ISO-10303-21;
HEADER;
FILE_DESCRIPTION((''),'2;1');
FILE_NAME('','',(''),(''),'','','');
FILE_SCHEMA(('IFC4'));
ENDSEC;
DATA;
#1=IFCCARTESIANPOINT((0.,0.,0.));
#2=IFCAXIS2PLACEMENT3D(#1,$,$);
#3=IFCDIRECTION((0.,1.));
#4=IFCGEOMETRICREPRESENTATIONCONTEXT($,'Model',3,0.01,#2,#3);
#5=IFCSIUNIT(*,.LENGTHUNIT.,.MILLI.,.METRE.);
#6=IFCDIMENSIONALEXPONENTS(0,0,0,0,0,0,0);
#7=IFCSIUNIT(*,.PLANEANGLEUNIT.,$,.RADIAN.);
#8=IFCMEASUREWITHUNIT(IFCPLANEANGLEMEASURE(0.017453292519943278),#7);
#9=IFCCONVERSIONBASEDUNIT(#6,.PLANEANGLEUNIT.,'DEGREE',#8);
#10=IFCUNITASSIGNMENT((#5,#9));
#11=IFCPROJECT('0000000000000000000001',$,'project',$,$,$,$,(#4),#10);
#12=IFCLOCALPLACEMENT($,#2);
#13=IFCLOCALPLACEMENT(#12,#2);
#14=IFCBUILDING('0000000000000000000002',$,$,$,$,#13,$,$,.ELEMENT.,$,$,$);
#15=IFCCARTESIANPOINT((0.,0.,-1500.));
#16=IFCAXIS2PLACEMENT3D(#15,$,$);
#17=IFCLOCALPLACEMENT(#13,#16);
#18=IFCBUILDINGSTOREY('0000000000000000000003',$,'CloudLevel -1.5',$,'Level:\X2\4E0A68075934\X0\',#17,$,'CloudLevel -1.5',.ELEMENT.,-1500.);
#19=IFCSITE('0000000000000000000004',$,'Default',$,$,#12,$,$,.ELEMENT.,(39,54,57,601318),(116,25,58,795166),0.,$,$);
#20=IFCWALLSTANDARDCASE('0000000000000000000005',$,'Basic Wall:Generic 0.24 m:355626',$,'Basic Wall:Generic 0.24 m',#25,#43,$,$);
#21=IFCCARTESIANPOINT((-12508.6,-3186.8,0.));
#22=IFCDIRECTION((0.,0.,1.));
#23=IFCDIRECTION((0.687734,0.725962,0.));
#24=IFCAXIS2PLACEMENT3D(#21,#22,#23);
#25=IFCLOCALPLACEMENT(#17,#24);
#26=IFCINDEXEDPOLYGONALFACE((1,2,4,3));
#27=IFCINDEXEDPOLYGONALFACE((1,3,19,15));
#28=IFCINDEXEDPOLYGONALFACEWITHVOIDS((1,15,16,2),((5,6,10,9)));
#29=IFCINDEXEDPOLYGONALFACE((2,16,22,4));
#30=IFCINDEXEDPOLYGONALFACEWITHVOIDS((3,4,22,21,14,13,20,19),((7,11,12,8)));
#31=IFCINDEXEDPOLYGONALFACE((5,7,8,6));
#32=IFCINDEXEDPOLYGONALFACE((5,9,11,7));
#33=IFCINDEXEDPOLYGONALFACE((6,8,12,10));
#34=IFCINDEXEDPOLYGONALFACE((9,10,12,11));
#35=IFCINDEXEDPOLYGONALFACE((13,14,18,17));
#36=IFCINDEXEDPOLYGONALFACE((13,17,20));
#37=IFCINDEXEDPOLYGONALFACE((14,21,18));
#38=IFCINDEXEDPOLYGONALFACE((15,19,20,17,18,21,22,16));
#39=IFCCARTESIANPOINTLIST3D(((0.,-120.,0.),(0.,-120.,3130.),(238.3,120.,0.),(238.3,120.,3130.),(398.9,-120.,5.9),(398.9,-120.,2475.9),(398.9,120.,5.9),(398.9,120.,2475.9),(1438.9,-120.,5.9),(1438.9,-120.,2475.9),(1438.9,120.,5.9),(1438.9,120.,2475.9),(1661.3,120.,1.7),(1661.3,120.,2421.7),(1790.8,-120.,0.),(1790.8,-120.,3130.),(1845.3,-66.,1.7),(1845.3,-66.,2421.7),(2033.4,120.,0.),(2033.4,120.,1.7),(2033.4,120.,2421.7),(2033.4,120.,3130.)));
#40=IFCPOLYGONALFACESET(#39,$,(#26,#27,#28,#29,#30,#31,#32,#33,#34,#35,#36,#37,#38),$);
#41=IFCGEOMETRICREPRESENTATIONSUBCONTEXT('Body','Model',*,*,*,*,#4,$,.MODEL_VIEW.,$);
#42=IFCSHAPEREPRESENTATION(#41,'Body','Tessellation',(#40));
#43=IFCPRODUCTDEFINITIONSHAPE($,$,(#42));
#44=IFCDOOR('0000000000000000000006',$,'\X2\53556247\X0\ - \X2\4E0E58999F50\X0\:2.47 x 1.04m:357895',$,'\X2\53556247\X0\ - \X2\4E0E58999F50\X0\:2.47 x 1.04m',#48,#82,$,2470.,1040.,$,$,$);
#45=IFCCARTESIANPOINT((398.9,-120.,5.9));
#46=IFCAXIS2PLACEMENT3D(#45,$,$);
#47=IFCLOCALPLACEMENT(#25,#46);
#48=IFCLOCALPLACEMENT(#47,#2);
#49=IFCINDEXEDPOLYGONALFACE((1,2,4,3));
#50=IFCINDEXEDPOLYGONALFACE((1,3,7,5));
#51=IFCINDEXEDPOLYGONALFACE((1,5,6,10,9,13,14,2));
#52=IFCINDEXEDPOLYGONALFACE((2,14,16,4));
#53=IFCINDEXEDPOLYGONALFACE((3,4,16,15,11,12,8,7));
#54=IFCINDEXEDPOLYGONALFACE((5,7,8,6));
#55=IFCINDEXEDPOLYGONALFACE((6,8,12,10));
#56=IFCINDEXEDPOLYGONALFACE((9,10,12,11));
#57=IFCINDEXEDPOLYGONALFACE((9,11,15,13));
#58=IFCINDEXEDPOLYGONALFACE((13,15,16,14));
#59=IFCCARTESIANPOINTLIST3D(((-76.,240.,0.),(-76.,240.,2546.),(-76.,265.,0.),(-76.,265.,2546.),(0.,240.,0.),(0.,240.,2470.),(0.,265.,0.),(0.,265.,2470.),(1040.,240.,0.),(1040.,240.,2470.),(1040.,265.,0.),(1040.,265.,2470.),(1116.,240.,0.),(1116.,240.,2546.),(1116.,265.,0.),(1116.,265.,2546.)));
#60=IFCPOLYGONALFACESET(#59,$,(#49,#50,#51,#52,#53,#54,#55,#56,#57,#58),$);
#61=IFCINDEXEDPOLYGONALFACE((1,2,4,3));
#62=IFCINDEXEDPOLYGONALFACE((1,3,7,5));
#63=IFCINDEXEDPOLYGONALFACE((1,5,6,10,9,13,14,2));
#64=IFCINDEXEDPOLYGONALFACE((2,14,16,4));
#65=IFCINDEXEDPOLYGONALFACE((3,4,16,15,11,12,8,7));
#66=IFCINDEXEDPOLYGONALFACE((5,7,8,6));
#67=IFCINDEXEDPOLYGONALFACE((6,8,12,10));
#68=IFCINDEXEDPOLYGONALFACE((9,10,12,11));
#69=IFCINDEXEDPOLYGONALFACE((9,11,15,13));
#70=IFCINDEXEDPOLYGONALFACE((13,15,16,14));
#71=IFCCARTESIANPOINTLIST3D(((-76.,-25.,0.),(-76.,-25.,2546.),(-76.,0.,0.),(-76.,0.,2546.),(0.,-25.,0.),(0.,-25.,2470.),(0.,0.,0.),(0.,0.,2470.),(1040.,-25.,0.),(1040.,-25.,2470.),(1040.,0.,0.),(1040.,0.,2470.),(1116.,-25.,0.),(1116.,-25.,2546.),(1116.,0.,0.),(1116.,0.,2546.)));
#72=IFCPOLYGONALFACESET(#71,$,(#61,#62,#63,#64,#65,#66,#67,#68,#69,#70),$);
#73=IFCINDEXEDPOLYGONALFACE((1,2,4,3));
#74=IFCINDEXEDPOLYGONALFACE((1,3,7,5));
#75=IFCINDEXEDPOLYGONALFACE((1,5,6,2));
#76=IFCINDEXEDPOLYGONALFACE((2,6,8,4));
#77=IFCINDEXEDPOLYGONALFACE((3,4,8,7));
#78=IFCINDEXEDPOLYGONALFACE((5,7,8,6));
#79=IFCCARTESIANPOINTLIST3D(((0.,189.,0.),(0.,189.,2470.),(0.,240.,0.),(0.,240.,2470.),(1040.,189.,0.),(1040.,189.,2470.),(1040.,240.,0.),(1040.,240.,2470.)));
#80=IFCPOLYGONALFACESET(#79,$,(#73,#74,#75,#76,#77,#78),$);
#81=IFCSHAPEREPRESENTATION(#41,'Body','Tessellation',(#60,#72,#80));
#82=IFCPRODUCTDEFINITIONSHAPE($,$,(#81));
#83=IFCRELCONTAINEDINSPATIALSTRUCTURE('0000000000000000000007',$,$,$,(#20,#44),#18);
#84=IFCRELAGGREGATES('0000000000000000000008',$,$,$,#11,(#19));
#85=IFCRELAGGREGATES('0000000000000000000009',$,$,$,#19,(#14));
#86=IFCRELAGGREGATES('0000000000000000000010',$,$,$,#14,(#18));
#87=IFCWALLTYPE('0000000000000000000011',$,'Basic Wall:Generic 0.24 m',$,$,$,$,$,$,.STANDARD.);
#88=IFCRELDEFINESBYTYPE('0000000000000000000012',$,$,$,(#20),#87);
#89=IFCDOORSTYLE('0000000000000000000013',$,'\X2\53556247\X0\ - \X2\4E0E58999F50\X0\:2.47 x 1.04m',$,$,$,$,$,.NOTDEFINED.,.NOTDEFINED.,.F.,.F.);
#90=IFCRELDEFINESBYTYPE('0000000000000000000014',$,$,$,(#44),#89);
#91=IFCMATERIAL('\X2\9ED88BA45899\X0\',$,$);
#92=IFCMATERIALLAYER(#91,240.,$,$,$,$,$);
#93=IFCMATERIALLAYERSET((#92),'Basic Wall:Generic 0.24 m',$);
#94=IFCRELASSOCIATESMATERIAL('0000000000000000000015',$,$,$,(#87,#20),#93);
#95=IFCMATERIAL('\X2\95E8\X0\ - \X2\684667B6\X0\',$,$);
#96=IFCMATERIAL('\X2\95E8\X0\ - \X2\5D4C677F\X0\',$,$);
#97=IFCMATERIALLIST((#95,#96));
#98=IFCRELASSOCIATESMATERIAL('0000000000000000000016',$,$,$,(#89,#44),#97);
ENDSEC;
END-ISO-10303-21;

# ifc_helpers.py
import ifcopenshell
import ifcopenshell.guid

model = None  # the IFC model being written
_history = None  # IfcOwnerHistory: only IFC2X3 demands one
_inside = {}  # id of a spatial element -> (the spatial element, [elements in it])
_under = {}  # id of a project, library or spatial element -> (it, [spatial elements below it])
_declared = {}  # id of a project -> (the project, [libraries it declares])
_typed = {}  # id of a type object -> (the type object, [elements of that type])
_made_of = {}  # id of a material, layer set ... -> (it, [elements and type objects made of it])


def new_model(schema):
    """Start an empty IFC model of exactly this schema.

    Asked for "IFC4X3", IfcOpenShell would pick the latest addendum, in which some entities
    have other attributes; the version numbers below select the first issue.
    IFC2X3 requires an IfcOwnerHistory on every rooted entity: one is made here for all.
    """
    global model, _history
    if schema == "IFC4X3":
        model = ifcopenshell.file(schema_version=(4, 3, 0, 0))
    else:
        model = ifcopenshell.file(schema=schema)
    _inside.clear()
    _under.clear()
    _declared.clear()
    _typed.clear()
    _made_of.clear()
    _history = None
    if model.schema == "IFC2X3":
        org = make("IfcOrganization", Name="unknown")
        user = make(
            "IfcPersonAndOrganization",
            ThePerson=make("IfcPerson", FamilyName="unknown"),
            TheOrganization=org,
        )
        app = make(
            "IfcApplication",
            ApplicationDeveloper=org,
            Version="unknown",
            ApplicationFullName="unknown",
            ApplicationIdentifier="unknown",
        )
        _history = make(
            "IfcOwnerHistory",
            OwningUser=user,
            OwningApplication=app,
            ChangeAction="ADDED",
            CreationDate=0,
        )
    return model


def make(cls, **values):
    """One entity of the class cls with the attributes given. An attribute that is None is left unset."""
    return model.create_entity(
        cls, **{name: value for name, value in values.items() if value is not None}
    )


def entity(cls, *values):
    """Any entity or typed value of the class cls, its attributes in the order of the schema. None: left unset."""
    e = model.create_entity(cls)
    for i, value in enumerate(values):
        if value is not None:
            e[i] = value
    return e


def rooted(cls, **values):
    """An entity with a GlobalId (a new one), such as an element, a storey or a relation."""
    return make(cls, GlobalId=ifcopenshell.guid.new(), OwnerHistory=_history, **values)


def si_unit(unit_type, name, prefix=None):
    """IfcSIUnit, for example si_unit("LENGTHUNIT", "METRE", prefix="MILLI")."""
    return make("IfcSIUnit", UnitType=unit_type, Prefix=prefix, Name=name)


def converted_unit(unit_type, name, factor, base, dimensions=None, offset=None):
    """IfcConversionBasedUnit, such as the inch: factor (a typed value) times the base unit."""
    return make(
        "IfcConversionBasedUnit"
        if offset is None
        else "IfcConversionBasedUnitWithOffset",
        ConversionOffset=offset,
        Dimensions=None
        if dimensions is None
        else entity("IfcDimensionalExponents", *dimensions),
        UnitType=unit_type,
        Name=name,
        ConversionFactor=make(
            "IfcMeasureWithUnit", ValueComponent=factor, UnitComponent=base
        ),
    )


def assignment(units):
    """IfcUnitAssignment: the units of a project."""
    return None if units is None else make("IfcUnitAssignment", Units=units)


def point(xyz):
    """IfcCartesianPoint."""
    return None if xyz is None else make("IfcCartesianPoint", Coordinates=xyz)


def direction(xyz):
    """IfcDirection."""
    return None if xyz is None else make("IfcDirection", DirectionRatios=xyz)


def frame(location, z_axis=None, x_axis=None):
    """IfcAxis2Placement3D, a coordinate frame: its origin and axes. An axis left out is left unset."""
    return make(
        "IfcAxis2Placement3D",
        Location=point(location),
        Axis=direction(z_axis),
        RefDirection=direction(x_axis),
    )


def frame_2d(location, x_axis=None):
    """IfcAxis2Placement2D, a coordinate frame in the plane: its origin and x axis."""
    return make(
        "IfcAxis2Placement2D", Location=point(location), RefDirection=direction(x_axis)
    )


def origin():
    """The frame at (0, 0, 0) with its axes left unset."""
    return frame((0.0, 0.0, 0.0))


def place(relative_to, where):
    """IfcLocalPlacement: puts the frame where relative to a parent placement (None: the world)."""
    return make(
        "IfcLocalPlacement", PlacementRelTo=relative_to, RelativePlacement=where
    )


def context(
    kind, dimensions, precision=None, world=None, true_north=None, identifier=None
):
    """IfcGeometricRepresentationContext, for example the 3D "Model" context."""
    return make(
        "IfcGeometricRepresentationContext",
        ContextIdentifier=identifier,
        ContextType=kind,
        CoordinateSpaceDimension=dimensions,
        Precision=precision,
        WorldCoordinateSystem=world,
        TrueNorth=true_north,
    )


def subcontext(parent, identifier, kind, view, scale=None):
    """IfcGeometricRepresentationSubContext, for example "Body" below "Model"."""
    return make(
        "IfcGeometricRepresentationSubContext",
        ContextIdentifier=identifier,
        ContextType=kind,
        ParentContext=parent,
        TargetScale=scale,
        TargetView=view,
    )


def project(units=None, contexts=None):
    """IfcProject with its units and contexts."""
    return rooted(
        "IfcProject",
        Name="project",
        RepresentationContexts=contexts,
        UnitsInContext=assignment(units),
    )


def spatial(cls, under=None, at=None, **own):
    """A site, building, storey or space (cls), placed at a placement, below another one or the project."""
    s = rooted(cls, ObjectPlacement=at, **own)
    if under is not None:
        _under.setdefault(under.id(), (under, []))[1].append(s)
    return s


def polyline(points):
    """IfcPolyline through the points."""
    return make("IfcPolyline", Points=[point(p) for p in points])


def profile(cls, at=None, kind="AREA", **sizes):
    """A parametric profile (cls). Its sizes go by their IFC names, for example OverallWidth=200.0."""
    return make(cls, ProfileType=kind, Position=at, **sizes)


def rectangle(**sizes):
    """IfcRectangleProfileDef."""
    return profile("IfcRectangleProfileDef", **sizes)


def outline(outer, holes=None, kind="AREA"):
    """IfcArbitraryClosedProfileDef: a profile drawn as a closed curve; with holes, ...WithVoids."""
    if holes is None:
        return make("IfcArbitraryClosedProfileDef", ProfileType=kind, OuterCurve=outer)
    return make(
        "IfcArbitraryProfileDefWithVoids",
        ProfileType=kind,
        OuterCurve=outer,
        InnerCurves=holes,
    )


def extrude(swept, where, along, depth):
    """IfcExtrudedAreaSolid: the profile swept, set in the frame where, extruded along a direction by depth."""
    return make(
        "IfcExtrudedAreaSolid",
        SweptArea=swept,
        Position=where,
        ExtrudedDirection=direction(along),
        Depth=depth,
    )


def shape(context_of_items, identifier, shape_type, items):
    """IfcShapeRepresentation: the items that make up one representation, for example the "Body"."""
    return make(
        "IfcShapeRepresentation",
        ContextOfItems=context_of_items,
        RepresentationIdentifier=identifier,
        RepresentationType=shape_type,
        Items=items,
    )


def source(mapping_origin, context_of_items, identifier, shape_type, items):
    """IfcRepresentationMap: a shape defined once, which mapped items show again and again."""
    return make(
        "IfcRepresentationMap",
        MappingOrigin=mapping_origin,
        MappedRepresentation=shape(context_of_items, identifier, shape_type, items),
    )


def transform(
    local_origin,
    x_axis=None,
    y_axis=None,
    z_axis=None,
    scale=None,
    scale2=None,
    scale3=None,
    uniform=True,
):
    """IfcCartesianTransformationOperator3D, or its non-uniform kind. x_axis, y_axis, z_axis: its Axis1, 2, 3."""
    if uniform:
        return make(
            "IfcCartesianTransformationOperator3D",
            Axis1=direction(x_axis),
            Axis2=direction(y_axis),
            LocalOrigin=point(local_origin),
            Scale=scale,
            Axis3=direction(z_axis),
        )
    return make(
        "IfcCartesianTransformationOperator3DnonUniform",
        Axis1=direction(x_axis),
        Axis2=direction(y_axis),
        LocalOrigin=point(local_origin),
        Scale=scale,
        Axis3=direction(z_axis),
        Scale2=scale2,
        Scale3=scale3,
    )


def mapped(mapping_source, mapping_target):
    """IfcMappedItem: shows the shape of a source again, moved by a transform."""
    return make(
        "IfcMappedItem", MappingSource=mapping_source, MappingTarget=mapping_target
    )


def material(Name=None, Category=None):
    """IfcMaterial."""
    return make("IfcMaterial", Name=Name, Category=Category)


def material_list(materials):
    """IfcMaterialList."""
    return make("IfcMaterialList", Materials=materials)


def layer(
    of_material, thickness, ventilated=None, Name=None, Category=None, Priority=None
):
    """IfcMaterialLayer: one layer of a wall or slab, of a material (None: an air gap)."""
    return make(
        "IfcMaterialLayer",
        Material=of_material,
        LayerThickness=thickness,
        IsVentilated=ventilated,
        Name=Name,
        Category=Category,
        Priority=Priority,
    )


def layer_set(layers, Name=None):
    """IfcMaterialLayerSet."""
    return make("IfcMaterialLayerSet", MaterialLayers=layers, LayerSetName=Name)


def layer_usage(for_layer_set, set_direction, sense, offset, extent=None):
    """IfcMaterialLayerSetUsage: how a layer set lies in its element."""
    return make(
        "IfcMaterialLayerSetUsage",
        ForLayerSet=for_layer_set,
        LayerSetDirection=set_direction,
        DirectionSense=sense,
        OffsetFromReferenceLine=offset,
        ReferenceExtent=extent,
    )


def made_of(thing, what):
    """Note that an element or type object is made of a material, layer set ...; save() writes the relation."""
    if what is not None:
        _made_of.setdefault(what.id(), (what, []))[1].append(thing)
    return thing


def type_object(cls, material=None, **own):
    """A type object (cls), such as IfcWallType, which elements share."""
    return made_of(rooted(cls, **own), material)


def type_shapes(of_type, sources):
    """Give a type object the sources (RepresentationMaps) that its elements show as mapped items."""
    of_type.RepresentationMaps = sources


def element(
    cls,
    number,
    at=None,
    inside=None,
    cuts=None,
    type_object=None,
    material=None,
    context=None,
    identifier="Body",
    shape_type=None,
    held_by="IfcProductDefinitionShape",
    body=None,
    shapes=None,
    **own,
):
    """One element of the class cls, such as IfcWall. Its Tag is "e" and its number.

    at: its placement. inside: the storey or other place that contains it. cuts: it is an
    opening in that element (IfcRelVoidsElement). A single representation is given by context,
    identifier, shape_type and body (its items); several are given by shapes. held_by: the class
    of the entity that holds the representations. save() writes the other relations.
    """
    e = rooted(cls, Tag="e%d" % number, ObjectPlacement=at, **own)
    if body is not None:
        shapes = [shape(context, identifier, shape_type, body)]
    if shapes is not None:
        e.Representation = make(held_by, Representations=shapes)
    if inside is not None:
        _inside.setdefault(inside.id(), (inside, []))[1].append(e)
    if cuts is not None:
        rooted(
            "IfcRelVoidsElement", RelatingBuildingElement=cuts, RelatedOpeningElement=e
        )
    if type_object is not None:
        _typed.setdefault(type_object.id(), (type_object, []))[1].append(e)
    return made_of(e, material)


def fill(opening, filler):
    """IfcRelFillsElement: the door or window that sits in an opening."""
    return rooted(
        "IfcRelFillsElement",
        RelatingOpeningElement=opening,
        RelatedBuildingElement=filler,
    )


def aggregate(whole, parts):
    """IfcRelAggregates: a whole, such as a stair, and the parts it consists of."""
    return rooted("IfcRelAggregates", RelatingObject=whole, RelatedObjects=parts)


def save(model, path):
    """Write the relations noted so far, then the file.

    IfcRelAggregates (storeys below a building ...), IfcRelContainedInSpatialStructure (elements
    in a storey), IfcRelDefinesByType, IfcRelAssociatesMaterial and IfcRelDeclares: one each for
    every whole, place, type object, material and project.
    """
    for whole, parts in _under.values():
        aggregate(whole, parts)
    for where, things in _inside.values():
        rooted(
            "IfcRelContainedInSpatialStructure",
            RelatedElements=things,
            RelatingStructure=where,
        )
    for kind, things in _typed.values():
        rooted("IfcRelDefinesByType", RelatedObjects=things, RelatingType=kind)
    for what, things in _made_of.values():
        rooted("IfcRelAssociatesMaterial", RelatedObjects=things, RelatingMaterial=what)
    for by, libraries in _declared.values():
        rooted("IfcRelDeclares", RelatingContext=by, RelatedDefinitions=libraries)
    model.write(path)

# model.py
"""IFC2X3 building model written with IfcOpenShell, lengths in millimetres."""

from ifc_helpers import new_model, entity, si_unit, converted_unit, direction, frame, frame_2d, origin, place, context, subcontext, project, spatial, polyline, rectangle, outline, extrude, source, transform, mapped, material, material_list, layer, layer_set, layer_usage, type_object, type_shapes, element, fill, save


model = new_model("IFC2X3")

# Units and contexts
model_context = context("Model", 3, precision=0.01, world=origin(), true_north=direction((0.0, 1.0)))
body_context = subcontext(model_context, "Body", "Model", "MODEL_VIEW")
ifc_project = project(units=[si_unit("LENGTHUNIT", "METRE", prefix="MILLI"), converted_unit("PLANEANGLEUNIT", "DEGREE", entity("IfcPlaneAngleMeasure", 0.017453292519943278), si_unit("PLANEANGLEUNIT", "RADIAN"), dimensions=[0, 0, 0, 0, 0, 0, 0])], contexts=[model_context])

# Site, building, storey
site_placement = place(None, origin())
site = spatial("IfcSite", under=ifc_project, at=site_placement, Name="Default", CompositionType="ELEMENT", RefLatitude=(39, 54, 57, 601318), RefLongitude=(116, 25, 58, 795166), RefElevation=0.0)
building_placement = place(site_placement, origin())
building = spatial("IfcBuilding", under=site, at=building_placement, CompositionType="ELEMENT")
storey_placement = place(building_placement, frame((0.0, 0.0, -1500.0)))
storey = spatial("IfcBuildingStorey", under=building, at=storey_placement, Name="CloudLevel -1.5", ObjectType="Level:上标头", LongName="CloudLevel -1.5", CompositionType="ELEMENT", Elevation=-1500.0)

# Wall, openings, door
ifc_material_1 = material(Name="默认墙")
ifc_layer_1 = layer(ifc_material_1, 240.0)
ifc_layer_set_1 = layer_set([ifc_layer_1], Name="Basic Wall:Generic 0.24 m")
ifc_layer_usage_1 = layer_usage(ifc_layer_set_1, "AXIS2", "NEGATIVE", 120.0)
wall_type_1 = type_object("IfcWallType", Name="Basic Wall:Generic 0.24 m", PredefinedType="STANDARD", material=ifc_layer_set_1)
wall_1_placement = place(storey_placement, frame((-12508.6, -3186.8, 0.0), z_axis=(0.0, 0.0, 1.0), x_axis=(0.687734, 0.725962, 0.0)))
wall_1 = element("IfcWallStandardCase", 1, at=wall_1_placement, inside=storey, type_object=wall_type_1, material=ifc_layer_usage_1, Name="Basic Wall:Generic 0.24 m:355626", ObjectType="Basic Wall:Generic 0.24 m", context=body_context, shape_type="SweptSolid", body=[
    extrude(outline(polyline([(1790.8, -120.0), (2033.4, 120.0), (1478.8, 120.0), (238.3, 120.0), (91.5, -27.8), (0.0, -120.0), (338.2, -120.0), (1790.8, -120.0)])), origin(), (0.0, 0.0, 1.0), 3130.0),
])
opening_1_placement = place(wall_1_placement, origin())
element("IfcOpeningElement", 2, at=opening_1_placement, cuts=wall_1, ObjectType="Opening", context=body_context, shape_type="SweptSolid", body=[
    extrude(rectangle(XDim=2420.0, YDim=2570.0, at=frame_2d((0.0, 0.0), x_axis=(1.0, 0.0))), frame((2758.8, 837.7, 1211.7), z_axis=(-0.703293, 0.7109, 0.0), x_axis=(0.0, 0.0, 1.0)), (0.0, 0.0, 1.0), 390.0),
])
opening_2_placement = place(wall_1_placement, frame((398.9, -120.0, 5.9)))
opening_2 = element("IfcOpeningElement", 3, at=opening_2_placement, cuts=wall_1, ObjectType="Opening", context=body_context, shape_type="SweptSolid", body=[
    extrude(rectangle(XDim=1040.0, YDim=2470.0, at=frame_2d((1235.0, 520.0), x_axis=(0.0, 1.0))), frame((0.0, 0.0, 0.0), z_axis=(0.0, 1.0, 0.0), x_axis=(0.0, 0.0, 1.0)), (0.0, 0.0, 1.0), 240.0),
])
ifc_material_2 = material(Name="门 - 框架")
ifc_material_3 = material(Name="门 - 嵌板")
ifc_material_list_1 = material_list([ifc_material_2, ifc_material_3])
door_style_1 = type_object("IfcDoorStyle", Name="单扇 - 与墙齐:2.47 x 1.04m", ConstructionType="NOTDEFINED", OperationType="NOTDEFINED", ParameterTakesPrecedence=False, Sizeable=False, material=ifc_material_list_1)
shared_shape_1 = source(origin(), body_context, "Body", "SweptSolid", [
    extrude(outline(polyline([(-596.0, -1292.0), (596.0, -1292.0), (596.0, 1254.0), (520.0, 1254.0), (520.0, -1216.0), (-520.0, -1216.0), (-520.0, 1254.0), (-596.0, 1254.0), (-596.0, -1292.0)])), frame((520.0, 240.0, 1254.0), z_axis=(0.0, 1.0, 0.0), x_axis=(1.0, 0.0, 0.0)), (0.0, 0.0, 1.0), 25.0),
    extrude(outline(polyline([(-1292.0, -596.0), (1254.0, -596.0), (1254.0, -520.0), (-1216.0, -520.0), (-1216.0, 520.0), (1254.0, 520.0), (1254.0, 596.0), (-1292.0, 596.0), (-1292.0, -596.0)])), frame((520.0, -25.0, 1254.0), z_axis=(0.0, 1.0, 0.0), x_axis=(0.0, 0.0, -1.0)), (0.0, 0.0, 1.0), 25.0),
    extrude(rectangle(XDim=51.0, YDim=1040.0, at=frame_2d((0.0, 0.0), x_axis=(1.0, 0.0))), frame((520.0, 214.5, 0.0), z_axis=(0.0, 0.0, 1.0), x_axis=(0.0, 1.0, 0.0)), (0.0, 0.0, 1.0), 2470.0),
])
type_shapes(door_style_1, [shared_shape_1])
door_1_placement = place(opening_2_placement, frame((0.0, 0.0, 0.0)))
door_1 = element("IfcDoor", 4, at=door_1_placement, inside=storey, type_object=door_style_1, material=ifc_material_list_1, Name="单扇 - 与墙齐:2.47 x 1.04m:357895", ObjectType="单扇 - 与墙齐:2.47 x 1.04m", OverallHeight=2470.0, OverallWidth=1040.0, context=body_context, shape_type="MappedRepresentation", body=[
    mapped(shared_shape_1, transform((0.0, 0.0, 0.0), scale=1.0)),
])
fill(opening_2, door_1)

save(model, "model.ifc")
